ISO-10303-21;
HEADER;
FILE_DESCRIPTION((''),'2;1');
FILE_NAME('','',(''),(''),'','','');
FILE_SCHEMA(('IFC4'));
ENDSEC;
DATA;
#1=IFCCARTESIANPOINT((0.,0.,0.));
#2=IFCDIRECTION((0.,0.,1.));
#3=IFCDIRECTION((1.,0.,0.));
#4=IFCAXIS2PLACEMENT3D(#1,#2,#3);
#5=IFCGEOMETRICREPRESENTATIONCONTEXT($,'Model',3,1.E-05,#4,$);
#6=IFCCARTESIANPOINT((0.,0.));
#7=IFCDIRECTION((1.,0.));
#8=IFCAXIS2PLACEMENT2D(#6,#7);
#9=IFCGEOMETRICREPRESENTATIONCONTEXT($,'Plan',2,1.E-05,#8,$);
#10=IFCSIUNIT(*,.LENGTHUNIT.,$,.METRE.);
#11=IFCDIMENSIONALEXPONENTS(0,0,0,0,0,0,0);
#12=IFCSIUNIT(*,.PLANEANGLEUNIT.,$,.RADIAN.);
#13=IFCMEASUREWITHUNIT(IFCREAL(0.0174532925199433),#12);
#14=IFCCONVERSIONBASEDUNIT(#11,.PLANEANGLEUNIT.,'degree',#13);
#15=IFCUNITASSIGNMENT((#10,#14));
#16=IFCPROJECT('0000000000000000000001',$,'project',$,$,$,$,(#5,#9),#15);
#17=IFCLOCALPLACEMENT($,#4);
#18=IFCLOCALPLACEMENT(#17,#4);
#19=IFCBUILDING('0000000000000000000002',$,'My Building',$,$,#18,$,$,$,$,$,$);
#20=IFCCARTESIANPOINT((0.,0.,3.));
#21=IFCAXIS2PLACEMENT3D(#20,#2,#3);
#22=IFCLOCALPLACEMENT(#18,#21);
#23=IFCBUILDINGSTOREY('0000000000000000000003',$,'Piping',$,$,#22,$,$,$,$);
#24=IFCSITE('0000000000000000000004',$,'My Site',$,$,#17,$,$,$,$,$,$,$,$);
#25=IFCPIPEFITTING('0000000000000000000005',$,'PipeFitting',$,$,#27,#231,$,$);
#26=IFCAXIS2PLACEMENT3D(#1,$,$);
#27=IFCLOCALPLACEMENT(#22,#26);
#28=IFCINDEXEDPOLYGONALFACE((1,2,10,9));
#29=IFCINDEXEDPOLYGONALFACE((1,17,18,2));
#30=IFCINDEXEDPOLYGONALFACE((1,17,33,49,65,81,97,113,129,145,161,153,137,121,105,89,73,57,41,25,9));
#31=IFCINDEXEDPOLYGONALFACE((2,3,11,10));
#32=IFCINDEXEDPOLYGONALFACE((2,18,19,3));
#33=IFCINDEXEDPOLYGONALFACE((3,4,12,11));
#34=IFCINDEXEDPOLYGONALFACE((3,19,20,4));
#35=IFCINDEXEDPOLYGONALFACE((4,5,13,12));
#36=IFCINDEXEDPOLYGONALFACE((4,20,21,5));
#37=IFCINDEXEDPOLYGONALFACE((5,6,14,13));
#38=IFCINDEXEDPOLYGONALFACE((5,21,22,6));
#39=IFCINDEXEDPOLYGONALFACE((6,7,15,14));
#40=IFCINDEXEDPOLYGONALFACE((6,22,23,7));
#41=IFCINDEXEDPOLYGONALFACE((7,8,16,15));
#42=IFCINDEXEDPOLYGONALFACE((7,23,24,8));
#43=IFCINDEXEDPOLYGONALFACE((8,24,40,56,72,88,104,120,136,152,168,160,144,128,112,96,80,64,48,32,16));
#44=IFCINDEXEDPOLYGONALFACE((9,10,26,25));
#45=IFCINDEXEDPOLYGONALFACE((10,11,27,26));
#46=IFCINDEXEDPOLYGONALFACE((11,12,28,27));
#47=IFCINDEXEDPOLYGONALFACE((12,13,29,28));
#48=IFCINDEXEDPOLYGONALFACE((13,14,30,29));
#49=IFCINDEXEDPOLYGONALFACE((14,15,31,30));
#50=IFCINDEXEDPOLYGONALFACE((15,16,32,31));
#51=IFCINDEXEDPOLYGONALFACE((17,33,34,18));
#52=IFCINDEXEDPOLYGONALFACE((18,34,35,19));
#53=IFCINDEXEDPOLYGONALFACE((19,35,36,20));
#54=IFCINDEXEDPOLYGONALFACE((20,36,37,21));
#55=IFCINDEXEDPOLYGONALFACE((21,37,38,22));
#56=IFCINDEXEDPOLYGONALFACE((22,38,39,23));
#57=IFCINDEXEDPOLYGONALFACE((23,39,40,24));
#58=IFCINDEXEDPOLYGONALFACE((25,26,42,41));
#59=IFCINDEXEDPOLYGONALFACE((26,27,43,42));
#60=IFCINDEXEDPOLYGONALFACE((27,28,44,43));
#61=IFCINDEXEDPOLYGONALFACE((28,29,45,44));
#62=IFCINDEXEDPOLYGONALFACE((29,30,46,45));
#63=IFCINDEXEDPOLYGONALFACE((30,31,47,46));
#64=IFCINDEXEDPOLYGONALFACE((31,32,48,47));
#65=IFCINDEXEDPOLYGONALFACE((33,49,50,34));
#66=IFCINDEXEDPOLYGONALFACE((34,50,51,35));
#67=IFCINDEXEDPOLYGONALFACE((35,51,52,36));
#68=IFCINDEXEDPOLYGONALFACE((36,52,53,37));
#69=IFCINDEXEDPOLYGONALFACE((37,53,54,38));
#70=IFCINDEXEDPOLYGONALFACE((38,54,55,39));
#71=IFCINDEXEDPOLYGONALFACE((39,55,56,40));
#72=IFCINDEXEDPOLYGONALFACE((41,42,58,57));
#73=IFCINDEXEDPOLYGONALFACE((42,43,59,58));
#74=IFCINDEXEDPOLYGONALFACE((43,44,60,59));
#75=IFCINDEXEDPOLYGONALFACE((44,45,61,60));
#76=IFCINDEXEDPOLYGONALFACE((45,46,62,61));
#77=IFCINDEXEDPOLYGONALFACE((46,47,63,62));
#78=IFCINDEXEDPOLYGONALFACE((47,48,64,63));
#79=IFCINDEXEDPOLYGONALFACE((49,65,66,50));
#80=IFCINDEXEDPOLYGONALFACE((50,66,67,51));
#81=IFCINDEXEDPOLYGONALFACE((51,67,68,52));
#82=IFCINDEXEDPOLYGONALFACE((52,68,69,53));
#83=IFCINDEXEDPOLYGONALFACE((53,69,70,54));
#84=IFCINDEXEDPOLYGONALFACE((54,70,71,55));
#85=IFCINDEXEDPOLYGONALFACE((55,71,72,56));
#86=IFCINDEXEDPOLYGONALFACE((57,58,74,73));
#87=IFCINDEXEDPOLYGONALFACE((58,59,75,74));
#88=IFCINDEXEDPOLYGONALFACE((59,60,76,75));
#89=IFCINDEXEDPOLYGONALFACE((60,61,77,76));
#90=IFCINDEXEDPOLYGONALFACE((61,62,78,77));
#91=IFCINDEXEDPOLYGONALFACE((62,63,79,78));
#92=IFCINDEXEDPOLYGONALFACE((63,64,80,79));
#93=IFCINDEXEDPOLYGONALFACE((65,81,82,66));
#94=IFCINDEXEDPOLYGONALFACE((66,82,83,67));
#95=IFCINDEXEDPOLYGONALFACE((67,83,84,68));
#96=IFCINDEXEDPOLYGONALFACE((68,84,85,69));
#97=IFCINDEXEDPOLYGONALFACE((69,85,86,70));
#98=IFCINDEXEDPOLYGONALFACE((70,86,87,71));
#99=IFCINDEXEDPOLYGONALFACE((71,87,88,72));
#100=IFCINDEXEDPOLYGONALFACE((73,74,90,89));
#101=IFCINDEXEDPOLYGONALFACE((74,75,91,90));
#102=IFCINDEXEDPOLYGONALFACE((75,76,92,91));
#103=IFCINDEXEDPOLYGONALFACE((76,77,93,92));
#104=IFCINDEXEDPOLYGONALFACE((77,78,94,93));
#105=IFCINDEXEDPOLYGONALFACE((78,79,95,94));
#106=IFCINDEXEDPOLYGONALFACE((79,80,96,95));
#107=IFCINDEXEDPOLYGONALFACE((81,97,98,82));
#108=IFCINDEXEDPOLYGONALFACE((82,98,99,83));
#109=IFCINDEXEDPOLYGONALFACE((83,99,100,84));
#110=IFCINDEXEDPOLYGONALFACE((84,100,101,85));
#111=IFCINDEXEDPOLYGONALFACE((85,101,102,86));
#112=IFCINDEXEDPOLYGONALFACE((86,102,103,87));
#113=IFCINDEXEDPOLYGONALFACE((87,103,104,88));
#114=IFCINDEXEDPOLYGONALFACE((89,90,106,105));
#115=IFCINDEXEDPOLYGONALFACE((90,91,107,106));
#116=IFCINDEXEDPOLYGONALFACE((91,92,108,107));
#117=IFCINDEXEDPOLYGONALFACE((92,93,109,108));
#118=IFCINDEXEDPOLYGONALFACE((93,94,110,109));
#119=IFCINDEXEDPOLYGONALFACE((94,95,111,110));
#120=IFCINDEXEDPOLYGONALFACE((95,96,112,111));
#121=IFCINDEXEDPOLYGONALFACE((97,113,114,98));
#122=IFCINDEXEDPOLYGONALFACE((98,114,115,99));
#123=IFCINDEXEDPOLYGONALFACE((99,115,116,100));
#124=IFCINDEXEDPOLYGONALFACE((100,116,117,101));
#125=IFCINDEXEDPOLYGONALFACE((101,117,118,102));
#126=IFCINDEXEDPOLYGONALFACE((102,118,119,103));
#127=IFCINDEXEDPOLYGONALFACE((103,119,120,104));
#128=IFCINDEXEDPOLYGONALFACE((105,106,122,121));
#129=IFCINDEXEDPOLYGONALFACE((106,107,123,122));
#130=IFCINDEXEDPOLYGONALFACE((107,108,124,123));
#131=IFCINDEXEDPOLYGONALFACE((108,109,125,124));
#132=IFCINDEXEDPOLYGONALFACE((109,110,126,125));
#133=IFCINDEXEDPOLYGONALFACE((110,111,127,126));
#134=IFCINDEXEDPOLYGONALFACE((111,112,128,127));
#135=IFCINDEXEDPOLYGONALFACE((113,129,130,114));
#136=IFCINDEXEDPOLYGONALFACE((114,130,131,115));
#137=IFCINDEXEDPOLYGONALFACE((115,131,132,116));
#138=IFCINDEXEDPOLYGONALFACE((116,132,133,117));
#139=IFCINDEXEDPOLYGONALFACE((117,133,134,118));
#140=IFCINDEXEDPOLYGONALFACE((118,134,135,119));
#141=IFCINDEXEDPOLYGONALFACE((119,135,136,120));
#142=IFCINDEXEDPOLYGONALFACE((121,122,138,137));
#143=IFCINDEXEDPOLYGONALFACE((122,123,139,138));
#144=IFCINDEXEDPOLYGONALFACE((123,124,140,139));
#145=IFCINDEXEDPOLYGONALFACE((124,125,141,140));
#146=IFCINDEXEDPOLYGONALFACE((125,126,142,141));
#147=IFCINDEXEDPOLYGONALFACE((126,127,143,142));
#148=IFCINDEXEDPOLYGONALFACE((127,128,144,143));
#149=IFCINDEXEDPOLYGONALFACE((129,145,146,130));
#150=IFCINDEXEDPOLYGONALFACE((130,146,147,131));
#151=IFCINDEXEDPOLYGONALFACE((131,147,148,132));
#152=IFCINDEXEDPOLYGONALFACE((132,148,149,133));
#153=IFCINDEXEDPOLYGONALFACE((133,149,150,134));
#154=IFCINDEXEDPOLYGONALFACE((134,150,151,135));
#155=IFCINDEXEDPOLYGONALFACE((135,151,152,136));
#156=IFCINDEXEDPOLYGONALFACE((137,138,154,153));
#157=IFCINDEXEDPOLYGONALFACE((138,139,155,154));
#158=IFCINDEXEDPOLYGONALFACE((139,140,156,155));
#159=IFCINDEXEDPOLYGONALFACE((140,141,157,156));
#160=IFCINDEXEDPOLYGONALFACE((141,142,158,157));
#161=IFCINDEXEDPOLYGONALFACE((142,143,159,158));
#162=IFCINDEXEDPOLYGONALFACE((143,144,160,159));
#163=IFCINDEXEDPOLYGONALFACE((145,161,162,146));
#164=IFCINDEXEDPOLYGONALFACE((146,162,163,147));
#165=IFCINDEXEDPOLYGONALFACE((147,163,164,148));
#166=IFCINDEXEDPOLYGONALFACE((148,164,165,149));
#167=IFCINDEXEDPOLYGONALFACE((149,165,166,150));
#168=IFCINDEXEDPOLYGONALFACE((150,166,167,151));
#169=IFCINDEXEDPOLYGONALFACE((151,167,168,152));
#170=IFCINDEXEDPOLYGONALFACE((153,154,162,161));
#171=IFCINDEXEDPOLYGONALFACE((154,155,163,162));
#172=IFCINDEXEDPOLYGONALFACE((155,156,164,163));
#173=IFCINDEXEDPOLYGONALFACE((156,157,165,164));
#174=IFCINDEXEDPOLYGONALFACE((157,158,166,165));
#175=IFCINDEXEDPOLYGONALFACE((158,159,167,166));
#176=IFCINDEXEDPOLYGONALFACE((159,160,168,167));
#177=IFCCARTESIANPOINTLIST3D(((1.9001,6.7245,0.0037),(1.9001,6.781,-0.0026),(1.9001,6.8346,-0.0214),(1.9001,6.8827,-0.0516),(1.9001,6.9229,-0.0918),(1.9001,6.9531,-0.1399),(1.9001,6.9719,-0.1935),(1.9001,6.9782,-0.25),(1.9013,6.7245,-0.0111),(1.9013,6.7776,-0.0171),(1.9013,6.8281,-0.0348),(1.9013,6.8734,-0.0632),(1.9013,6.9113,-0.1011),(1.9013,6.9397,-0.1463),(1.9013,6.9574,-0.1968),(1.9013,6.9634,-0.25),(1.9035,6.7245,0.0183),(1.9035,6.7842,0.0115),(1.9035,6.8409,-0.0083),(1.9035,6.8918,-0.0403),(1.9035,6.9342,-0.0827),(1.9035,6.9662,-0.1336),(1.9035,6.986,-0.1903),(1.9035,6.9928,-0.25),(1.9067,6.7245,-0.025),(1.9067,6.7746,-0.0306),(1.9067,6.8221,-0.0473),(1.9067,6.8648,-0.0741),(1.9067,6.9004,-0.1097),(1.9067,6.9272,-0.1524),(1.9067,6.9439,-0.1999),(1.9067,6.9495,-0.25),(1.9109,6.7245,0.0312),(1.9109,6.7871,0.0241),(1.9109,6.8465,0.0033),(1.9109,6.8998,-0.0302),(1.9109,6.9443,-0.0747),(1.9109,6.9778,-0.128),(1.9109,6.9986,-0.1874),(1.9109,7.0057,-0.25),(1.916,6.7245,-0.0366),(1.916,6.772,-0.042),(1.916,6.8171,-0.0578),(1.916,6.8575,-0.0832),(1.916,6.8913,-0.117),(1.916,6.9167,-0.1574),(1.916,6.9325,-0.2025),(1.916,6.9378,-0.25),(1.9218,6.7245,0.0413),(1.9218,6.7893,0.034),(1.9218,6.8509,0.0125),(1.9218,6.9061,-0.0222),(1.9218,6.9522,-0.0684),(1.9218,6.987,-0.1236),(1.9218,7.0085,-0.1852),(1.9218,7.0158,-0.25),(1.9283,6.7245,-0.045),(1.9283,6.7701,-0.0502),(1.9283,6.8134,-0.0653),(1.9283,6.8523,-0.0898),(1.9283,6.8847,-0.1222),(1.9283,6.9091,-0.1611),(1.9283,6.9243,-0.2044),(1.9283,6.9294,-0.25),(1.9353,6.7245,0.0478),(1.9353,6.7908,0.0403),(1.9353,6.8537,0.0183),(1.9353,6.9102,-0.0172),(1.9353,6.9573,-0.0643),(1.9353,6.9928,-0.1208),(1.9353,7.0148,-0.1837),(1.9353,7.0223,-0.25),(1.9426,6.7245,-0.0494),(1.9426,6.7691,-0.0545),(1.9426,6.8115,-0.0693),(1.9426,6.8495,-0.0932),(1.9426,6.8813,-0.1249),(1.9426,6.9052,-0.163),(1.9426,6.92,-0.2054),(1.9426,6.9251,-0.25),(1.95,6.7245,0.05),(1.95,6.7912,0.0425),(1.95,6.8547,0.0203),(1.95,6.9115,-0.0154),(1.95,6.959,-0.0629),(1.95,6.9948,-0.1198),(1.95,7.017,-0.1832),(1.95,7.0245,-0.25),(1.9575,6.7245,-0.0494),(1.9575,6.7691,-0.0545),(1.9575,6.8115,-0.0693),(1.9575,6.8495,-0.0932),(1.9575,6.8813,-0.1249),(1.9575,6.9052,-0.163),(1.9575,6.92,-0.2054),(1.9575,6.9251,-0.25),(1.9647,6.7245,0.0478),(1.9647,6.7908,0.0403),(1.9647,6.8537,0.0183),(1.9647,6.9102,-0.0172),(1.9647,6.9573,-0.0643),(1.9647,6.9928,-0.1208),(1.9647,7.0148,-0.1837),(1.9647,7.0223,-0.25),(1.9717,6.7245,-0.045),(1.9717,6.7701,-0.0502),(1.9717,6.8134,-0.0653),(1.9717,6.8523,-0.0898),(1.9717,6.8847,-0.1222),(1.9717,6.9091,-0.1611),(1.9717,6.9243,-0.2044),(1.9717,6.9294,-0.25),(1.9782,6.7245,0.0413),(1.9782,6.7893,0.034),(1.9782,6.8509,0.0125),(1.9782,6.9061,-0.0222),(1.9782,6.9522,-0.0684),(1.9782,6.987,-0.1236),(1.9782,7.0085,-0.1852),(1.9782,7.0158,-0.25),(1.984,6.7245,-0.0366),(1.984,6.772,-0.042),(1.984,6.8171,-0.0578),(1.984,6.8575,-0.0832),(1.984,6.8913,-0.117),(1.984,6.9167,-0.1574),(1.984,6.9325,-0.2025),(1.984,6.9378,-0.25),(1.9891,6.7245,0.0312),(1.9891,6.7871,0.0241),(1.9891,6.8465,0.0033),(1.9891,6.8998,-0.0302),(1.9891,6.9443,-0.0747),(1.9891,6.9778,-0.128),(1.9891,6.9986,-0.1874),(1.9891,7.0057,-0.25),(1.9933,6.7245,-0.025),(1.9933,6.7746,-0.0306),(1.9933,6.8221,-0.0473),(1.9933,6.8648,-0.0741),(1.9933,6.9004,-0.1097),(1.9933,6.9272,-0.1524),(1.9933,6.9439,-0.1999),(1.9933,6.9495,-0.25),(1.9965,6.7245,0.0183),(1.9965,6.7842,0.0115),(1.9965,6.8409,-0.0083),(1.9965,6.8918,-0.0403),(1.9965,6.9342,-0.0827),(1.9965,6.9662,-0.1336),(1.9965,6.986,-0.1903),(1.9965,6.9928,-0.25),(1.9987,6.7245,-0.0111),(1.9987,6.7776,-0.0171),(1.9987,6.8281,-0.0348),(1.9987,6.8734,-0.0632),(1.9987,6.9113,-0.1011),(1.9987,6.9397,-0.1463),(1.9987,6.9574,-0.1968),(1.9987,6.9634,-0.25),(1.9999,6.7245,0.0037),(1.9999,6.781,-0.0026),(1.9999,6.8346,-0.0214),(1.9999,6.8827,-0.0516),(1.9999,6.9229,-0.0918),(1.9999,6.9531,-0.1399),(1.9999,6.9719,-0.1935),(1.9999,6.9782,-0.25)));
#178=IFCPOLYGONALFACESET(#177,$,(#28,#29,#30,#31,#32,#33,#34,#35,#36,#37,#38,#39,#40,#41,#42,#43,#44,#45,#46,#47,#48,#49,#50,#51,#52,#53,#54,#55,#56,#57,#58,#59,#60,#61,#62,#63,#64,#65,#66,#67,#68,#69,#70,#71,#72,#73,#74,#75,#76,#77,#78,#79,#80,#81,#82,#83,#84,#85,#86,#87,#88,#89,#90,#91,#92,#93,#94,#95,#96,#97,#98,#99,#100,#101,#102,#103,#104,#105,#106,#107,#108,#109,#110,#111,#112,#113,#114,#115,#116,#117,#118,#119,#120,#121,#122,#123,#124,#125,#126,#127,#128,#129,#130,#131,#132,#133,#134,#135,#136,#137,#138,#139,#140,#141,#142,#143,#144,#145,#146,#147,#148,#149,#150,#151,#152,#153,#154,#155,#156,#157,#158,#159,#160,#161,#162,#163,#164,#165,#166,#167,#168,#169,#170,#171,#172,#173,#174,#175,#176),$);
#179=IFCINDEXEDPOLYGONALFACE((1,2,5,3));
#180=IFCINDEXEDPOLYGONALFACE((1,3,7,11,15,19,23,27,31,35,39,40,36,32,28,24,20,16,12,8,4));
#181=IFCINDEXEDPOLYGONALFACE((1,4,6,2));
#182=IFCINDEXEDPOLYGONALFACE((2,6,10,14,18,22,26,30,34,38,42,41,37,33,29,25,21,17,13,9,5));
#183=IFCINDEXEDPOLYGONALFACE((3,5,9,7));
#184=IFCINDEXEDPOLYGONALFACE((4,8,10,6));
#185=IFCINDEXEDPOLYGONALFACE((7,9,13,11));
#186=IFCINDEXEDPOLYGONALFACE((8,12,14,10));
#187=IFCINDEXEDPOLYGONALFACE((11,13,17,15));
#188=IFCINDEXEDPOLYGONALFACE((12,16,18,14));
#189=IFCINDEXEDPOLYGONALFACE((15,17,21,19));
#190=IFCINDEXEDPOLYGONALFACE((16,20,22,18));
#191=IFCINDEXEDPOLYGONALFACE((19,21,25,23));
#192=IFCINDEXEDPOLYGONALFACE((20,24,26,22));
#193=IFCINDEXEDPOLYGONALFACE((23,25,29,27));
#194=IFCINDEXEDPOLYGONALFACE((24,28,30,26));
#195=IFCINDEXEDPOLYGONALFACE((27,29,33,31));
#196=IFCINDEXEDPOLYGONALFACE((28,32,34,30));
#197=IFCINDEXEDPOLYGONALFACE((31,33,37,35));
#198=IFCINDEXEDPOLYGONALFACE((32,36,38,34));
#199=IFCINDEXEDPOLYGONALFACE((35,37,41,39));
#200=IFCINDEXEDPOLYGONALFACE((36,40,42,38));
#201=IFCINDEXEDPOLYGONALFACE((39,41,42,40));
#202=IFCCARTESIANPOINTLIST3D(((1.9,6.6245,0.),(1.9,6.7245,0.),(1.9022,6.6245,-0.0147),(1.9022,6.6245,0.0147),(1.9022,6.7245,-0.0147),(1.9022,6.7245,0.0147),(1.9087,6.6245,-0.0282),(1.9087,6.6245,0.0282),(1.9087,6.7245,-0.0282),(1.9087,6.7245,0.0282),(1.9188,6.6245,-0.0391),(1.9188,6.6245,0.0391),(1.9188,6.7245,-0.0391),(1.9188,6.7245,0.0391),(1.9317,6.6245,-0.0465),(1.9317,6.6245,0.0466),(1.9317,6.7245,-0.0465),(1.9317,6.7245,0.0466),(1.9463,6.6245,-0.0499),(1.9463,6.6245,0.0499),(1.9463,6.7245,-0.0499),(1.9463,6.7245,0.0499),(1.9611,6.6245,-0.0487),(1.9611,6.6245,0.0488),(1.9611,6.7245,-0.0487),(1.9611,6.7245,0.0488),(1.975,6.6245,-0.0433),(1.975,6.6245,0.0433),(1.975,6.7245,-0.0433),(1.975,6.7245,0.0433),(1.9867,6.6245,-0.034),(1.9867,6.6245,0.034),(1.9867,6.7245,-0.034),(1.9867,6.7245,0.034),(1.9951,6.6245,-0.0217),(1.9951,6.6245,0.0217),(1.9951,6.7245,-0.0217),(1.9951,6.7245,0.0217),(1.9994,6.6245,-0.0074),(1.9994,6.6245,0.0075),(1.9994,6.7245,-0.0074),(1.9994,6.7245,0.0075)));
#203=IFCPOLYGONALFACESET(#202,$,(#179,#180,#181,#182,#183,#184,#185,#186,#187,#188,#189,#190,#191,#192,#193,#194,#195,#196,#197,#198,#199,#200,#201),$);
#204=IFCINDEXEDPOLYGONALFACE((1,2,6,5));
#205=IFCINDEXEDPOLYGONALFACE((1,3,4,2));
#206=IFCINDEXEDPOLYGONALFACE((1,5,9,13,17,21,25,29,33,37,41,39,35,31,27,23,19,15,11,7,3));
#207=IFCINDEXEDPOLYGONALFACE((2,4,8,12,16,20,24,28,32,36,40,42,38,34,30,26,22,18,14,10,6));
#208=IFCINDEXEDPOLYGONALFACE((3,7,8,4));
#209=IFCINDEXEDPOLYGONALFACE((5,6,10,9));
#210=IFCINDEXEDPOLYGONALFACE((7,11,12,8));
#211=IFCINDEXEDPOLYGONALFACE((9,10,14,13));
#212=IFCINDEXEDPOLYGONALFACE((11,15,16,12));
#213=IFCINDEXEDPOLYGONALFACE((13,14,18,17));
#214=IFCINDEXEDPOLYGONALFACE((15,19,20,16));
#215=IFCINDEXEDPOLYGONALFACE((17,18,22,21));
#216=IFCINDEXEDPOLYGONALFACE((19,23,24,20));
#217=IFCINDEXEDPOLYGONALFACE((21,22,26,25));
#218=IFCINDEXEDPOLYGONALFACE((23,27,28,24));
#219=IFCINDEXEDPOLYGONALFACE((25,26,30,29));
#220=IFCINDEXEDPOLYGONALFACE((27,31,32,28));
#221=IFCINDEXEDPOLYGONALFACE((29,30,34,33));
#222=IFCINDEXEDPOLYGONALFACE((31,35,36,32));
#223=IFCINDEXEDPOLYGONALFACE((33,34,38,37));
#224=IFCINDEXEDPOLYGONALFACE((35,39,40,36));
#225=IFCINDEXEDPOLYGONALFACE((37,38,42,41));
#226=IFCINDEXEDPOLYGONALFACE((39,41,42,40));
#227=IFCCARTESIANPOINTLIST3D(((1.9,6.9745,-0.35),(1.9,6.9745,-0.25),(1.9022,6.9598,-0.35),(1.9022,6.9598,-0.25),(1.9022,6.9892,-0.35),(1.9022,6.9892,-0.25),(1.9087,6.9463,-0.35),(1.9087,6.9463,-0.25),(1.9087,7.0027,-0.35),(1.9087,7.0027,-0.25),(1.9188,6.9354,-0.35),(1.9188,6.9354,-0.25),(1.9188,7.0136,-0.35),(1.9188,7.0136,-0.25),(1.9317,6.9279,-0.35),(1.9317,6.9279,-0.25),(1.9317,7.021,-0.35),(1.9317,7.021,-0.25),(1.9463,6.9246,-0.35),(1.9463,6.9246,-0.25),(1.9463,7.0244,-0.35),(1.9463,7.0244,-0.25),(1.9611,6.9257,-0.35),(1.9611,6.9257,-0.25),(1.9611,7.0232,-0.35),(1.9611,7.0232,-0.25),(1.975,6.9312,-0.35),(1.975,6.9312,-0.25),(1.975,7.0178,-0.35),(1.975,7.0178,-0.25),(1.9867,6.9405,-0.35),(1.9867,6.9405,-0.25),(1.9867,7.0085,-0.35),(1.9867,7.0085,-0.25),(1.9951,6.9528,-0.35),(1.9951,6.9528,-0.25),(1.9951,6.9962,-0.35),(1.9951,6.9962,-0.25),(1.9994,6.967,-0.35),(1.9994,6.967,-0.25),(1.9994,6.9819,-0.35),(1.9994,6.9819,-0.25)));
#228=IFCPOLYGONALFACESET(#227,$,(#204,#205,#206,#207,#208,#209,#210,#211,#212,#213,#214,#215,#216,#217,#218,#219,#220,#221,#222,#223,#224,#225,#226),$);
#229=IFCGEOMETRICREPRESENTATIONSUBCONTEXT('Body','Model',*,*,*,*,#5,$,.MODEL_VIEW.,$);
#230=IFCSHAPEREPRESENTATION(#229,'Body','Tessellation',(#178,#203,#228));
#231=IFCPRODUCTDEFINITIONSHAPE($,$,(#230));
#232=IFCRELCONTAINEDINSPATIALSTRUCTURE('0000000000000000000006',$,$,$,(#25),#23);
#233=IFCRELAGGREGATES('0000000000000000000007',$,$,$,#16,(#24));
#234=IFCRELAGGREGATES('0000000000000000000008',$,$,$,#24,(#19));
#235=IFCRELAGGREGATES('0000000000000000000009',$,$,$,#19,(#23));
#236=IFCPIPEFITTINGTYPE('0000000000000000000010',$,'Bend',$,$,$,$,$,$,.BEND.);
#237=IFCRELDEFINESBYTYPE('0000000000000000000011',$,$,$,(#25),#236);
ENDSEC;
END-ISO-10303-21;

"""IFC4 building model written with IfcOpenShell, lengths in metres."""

from ifc_helpers import new_model, entity, si_unit, converted_unit, frame, origin_with_axes, origin_2d_with_axis, place, context, subcontext, project, spatial, circle, extrude, source, transform, mapped, type_object, type_shapes, element, save


model = new_model("IFC4")

# Units and contexts
model_context = context("Model", 3, precision=1e-05, world=origin_with_axes())
plan_context = context("Plan", 2, precision=1e-05, world=origin_2d_with_axis())
body_context = subcontext(model_context, "Body", "Model", "MODEL_VIEW")
ifc_project = project(units=[si_unit("LENGTHUNIT", "METRE"), converted_unit("PLANEANGLEUNIT", "degree", entity("IfcReal", 0.0174532925199433), si_unit("PLANEANGLEUNIT", "RADIAN"), dimensions=[0, 0, 0, 0, 0, 0, 0])], contexts=[model_context, plan_context])

# Site, building, storey
site_placement = place(None, origin_with_axes())
site = spatial("IfcSite", under=ifc_project, at=site_placement, Name="My Site")
building_placement = place(site_placement, origin_with_axes())
building = spatial("IfcBuilding", under=site, at=building_placement, Name="My Building")
storey_placement = place(building_placement, frame((0.0, 0.0, 3.0), z_axis=(0.0, 0.0, 1.0), x_axis=(1.0, 0.0, 0.0)))
storey = spatial("IfcBuildingStorey", under=building, at=storey_placement, Name="Piping")

# Pipe fitting
pipe_fitting_type = type_object("IfcPipeFittingType", Name="Bend", PredefinedType="BEND")
shared_shape = source(origin_with_axes(), body_context, "Body", "SolidModel", [
    entity("IfcSweptDiskSolid", entity("IfcIndexedPolyCurve", entity("IfcCartesianPointList3D", [[0.0, 0.0, 0.1], [0.0, -0.0732, 0.2768], [0.0, -0.25, 0.35]]), [entity("IfcArcIndex", [1, 2, 3])]), 0.05),
    extrude(circle(Radius=0.05), origin_with_axes(), (0.0, 0.0, 1.0), 0.1),
    extrude(circle(Radius=0.05), frame((0.0, -0.25, 0.35), z_axis=(0.0, -1.0, 0.0), x_axis=(1.0, 0.0, 0.0)), (0.0, 0.0, 1.0), 0.1),
])
type_shapes(pipe_fitting_type, [shared_shape])
for number, where, z_axis, x_axis, name in (
    (1, (1.95, 6.6245, 0.0), (0.0, 1.0, 0.0), (-1.0, 0.0, 0.0), "PipeFitting"),
):
    element("IfcPipeFitting", number, at=place(storey_placement, frame(where, z_axis=z_axis, x_axis=x_axis)), inside=storey, type_object=pipe_fitting_type, Name=name, context=body_context, shape_type="MappedRepresentation", body=[
        mapped(shared_shape, transform((0.0, 0.0, 0.0), x_axis=(1.0, 0.0, 0.0), y_axis=(0.0, 1.0, 0.0), z_axis=(0.0, 0.0, 1.0), scale=1.0)),
    ])

save(model, "model.ifc")
